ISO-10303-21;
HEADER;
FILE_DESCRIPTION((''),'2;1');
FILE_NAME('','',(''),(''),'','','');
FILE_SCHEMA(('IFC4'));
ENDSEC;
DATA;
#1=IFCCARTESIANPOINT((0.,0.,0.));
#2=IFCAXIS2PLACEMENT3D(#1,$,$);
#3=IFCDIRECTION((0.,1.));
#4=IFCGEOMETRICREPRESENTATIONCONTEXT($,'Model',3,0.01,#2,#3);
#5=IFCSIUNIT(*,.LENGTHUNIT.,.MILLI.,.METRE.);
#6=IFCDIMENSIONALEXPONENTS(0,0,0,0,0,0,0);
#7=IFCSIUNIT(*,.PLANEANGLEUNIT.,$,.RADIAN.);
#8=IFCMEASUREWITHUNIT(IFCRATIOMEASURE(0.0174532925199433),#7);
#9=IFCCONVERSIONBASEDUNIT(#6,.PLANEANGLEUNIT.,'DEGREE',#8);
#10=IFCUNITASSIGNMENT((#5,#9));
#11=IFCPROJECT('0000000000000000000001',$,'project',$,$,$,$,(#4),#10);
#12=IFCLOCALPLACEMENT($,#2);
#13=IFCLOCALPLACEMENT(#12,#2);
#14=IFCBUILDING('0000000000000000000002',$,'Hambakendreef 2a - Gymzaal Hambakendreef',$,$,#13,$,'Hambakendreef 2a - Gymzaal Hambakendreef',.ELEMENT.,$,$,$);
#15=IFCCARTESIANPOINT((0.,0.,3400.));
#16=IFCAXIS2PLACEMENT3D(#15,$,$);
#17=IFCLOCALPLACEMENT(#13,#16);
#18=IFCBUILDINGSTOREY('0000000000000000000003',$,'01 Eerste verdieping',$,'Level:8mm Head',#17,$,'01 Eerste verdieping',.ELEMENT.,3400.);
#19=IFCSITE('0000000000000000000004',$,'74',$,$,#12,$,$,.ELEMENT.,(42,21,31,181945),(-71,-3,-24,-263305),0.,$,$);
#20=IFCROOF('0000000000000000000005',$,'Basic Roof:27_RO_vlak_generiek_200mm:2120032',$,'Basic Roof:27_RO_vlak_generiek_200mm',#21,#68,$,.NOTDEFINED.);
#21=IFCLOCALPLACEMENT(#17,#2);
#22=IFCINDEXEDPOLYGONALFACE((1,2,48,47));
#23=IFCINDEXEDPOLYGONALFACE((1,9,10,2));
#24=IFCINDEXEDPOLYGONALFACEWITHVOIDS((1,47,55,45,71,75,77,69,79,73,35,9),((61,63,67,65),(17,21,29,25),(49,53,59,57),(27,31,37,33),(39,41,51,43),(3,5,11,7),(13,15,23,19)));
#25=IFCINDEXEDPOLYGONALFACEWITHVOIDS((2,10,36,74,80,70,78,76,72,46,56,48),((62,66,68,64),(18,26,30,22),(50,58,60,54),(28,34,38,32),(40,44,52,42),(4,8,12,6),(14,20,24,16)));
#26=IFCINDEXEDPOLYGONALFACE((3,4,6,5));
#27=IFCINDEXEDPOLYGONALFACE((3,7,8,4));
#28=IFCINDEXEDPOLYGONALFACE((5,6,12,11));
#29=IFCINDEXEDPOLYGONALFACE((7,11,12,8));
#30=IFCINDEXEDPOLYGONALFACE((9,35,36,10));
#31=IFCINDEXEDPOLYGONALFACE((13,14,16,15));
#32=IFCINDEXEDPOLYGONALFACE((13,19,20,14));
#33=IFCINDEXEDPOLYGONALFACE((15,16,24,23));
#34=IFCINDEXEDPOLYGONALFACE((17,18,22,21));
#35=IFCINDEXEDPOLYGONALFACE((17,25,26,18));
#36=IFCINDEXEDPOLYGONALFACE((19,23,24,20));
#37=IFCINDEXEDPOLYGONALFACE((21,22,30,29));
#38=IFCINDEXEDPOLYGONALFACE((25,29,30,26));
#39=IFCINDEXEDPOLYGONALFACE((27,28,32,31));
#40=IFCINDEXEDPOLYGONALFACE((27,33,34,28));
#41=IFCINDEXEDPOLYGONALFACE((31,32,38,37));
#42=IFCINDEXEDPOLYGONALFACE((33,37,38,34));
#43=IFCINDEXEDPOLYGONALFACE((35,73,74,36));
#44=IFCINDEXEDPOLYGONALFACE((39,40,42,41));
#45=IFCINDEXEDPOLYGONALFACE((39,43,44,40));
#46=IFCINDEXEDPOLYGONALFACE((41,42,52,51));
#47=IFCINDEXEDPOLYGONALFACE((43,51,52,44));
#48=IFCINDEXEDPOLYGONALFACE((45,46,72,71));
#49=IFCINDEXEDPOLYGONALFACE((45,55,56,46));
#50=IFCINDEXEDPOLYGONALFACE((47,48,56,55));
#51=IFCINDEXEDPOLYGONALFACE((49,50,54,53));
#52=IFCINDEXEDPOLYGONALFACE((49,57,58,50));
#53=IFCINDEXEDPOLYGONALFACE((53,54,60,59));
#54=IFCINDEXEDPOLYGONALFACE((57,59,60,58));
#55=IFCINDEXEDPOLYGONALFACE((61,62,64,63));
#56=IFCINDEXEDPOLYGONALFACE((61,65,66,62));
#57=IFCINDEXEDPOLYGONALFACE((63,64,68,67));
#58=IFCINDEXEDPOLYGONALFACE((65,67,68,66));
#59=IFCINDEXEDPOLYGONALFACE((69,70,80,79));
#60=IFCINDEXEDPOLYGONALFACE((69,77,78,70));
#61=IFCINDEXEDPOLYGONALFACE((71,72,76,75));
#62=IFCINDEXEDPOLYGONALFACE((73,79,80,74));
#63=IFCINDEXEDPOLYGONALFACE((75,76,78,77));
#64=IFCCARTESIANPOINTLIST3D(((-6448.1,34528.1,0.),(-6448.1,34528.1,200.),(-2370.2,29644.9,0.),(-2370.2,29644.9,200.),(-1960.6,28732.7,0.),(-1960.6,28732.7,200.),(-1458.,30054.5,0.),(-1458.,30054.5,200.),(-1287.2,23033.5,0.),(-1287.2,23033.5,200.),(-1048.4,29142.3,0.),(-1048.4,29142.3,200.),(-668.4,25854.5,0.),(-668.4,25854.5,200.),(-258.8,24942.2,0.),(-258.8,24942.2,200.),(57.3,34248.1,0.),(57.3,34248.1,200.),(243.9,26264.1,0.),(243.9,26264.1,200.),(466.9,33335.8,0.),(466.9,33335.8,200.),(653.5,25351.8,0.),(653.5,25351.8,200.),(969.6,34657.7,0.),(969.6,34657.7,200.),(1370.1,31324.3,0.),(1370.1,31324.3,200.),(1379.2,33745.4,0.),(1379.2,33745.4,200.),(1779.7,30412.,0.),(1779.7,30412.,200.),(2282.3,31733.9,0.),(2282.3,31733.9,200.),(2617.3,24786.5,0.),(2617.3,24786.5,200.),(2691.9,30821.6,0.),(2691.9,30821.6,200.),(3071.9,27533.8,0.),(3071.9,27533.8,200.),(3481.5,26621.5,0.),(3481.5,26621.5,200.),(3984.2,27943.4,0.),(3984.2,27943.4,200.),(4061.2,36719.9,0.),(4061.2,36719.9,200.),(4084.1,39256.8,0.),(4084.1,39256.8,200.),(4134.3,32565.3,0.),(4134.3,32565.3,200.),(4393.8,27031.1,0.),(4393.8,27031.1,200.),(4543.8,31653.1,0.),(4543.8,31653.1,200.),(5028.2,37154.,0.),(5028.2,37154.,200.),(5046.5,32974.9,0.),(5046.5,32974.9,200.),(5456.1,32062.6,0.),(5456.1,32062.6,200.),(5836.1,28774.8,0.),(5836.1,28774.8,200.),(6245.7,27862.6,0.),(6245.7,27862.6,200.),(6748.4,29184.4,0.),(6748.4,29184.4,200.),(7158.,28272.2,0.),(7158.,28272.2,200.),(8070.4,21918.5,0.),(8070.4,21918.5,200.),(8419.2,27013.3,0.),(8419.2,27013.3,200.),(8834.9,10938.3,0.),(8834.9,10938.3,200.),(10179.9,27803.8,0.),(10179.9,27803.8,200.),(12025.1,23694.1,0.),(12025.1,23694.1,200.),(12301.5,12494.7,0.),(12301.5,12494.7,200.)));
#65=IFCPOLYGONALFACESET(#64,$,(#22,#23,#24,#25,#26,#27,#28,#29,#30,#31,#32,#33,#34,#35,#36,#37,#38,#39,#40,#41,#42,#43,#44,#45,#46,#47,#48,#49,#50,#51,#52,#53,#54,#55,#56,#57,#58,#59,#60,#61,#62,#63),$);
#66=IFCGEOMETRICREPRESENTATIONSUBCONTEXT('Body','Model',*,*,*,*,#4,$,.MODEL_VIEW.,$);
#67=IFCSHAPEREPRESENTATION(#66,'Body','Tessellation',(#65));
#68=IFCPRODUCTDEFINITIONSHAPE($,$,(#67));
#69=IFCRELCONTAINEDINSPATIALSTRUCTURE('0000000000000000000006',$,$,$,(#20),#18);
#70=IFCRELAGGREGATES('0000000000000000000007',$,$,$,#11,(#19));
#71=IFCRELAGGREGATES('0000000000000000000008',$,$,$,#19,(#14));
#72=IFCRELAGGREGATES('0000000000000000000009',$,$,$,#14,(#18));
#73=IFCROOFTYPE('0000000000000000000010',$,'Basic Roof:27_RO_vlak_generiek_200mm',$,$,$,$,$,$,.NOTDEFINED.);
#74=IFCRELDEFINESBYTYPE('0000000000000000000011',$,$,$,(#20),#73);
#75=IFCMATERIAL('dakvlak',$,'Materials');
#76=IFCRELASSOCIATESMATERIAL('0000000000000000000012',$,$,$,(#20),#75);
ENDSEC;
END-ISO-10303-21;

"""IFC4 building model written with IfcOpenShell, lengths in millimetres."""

from ifc_helpers import new_model, entity, si_unit, converted_unit, direction, frame, origin, place, context, subcontext, project, spatial, indexed_curve, outline, extrude, material, type_object, element, save


model = new_model("IFC4")

# Units and contexts
model_context = context("Model", 3, precision=0.01, world=origin(), true_north=direction((0.0, 1.0)))
body_context = subcontext(model_context, "Body", "Model", "MODEL_VIEW")
ifc_project = project(units=[si_unit("LENGTHUNIT", "METRE", prefix="MILLI"), converted_unit("PLANEANGLEUNIT", "DEGREE", entity("IfcRatioMeasure", 0.0174532925199433), si_unit("PLANEANGLEUNIT", "RADIAN"), dimensions=[0, 0, 0, 0, 0, 0, 0])], contexts=[model_context])

# Site, building, storey
site_placement = place(None, origin())
site = spatial("IfcSite", under=ifc_project, at=site_placement, Name="74", CompositionType="ELEMENT", RefLatitude=(42, 21, 31, 181945), RefLongitude=(-71, -3, -24, -263305), RefElevation=0.0)
building_placement = place(site_placement, origin())
building = spatial("IfcBuilding", under=site, at=building_placement, Name="Hambakendreef 2a - Gymzaal Hambakendreef", LongName="Hambakendreef 2a - Gymzaal Hambakendreef", CompositionType="ELEMENT")
storey_placement = place(building_placement, frame((0.0, 0.0, 3400.0)))
storey = spatial("IfcBuildingStorey", under=building, at=storey_placement, Name="01 Eerste verdieping", ObjectType="Level:8mm Head", LongName="01 Eerste verdieping", CompositionType="ELEMENT", Elevation=3400.0)

# Roof, openings
ifc_material_1 = material(Name="dakvlak", Category="Materials")
roof_type = type_object("IfcRoofType", Name="Basic Roof:27_RO_vlak_generiek_200mm", PredefinedType="NOTDEFINED")
roof_placement = place(storey_placement, origin())
roof = element("IfcRoof", 1, at=roof_placement, inside=storey, type_object=roof_type, material=ifc_material_1, Name="Basic Roof:27_RO_vlak_generiek_200mm:2120032", ObjectType="Basic Roof:27_RO_vlak_generiek_200mm", PredefinedType="NOTDEFINED", context=body_context, shape_type="SweptSolid", body=[
    extrude(outline(indexed_curve([(1342.5, -2958.1), (16522.5, -2958.1), (16522.5, 841.9), (6192.5, 841.9), (6192.5, 5176.9), (1687.5, 5176.9), (1687.5, 3246.9), (-8952.5, 3246.9), (-8952.5, 4306.9), (-11257.5, 4306.9), (-11257.5, -7238.1), (1342.5, -7238.1), (1342.5, -2958.1)], self_intersect=False)), frame((4766.0, 27222.9, 0.0), z_axis=(0.0, 0.0, 1.0), x_axis=(0.40959, -0.91227, 0.0)), (0.0, 0.0, 1.0), 200.0),
])
opening_1_placement = place(storey_placement, origin())
element("IfcOpeningElement", 2, at=opening_1_placement, cuts=roof, PredefinedType="OPENING", context=body_context, shape_type="SweptSolid", body=[
    extrude(outline(indexed_curve([(-500.0, -500.0), (500.0, -500.0), (500.0, 500.0), (-500.0, 500.0), (-500.0, -500.0)], self_intersect=False)), frame((718.3, 33996.7, 0.0), z_axis=(0.0, 0.0, 1.0), x_axis=(0.91227, 0.40959, 0.0)), (0.0, 0.0, 1.0), 200.0),
])
opening_2_placement = place(storey_placement, origin())
element("IfcOpeningElement", 3, at=opening_2_placement, cuts=roof, PredefinedType="OPENING", context=body_context, shape_type="SweptSolid", body=[
    extrude(outline(indexed_curve([(-500.0, -500.0), (500.0, -500.0), (500.0, 500.0), (-500.0, 500.0), (-500.0, -500.0)], self_intersect=False)), frame((2031.0, 31072.9, 0.0), z_axis=(0.0, 0.0, 1.0), x_axis=(0.91227, 0.40959, 0.0)), (0.0, 0.0, 1.0), 200.0),
])
opening_3_placement = place(storey_placement, origin())
element("IfcOpeningElement", 4, at=opening_3_placement, cuts=roof, PredefinedType="OPENING", context=body_context, shape_type="SweptSolid", body=[
    extrude(outline(indexed_curve([(-500.0, -500.0), (500.0, -500.0), (500.0, 500.0), (-500.0, 500.0), (-500.0, -500.0)], self_intersect=False)), frame((3732.9, 27282.4, 0.0), z_axis=(0.0, 0.0, 1.0), x_axis=(0.91227, 0.40959, 0.0)), (0.0, 0.0, 1.0), 200.0),
])
opening_4_placement = place(storey_placement, origin())
element("IfcOpeningElement", 5, at=opening_4_placement, cuts=roof, PredefinedType="OPENING", context=body_context, shape_type="SweptSolid", body=[
    extrude(outline(indexed_curve([(-500.0, -500.0), (500.0, -500.0), (500.0, 500.0), (-500.0, 500.0), (-500.0, -500.0)], self_intersect=False)), frame((4795.2, 32314.0, 0.0), z_axis=(0.0, 0.0, 1.0), x_axis=(0.91227, 0.40959, 0.0)), (0.0, 0.0, 1.0), 200.0),
])
opening_5_placement = place(storey_placement, origin())
element("IfcOpeningElement", 6, at=opening_5_placement, cuts=roof, PredefinedType="OPENING", context=body_context, shape_type="SweptSolid", body=[
    extrude(outline(indexed_curve([(-500.0, -500.0), (500.0, -500.0), (500.0, 500.0), (-500.0, 500.0), (-500.0, -500.0)], self_intersect=False)), frame((-1709.3, 29393.6, 0.0), z_axis=(0.0, 0.0, 1.0), x_axis=(0.91227, 0.40959, 0.0)), (0.0, 0.0, 1.0), 200.0),
])
opening_6_placement = place(storey_placement, origin())
element("IfcOpeningElement", 7, at=opening_6_placement, cuts=roof, PredefinedType="OPENING", context=body_context, shape_type="SweptSolid", body=[
    extrude(outline(indexed_curve([(-500.0, -500.0), (500.0, -500.0), (500.0, 500.0), (-500.0, 500.0), (-500.0, -500.0)], self_intersect=False)), frame((-7.4, 25603.1, 0.0), z_axis=(0.0, 0.0, 1.0), x_axis=(0.91227, 0.40959, 0.0)), (0.0, 0.0, 1.0), 200.0),
])
opening_7_placement = place(storey_placement, origin())
element("IfcOpeningElement", 8, at=opening_7_placement, cuts=roof, PredefinedType="OPENING", context=body_context, shape_type="SweptSolid", body=[
    extrude(outline(indexed_curve([(-500.0, -500.0), (500.0, -500.0), (500.0, 500.0), (-500.0, 500.0), (-500.0, -500.0)], self_intersect=False)), frame((6497.0, 28523.5, 0.0), z_axis=(0.0, 0.0, 1.0), x_axis=(0.91227, 0.40959, 0.0)), (0.0, 0.0, 1.0), 200.0),
])

save(model, "model.ifc")
